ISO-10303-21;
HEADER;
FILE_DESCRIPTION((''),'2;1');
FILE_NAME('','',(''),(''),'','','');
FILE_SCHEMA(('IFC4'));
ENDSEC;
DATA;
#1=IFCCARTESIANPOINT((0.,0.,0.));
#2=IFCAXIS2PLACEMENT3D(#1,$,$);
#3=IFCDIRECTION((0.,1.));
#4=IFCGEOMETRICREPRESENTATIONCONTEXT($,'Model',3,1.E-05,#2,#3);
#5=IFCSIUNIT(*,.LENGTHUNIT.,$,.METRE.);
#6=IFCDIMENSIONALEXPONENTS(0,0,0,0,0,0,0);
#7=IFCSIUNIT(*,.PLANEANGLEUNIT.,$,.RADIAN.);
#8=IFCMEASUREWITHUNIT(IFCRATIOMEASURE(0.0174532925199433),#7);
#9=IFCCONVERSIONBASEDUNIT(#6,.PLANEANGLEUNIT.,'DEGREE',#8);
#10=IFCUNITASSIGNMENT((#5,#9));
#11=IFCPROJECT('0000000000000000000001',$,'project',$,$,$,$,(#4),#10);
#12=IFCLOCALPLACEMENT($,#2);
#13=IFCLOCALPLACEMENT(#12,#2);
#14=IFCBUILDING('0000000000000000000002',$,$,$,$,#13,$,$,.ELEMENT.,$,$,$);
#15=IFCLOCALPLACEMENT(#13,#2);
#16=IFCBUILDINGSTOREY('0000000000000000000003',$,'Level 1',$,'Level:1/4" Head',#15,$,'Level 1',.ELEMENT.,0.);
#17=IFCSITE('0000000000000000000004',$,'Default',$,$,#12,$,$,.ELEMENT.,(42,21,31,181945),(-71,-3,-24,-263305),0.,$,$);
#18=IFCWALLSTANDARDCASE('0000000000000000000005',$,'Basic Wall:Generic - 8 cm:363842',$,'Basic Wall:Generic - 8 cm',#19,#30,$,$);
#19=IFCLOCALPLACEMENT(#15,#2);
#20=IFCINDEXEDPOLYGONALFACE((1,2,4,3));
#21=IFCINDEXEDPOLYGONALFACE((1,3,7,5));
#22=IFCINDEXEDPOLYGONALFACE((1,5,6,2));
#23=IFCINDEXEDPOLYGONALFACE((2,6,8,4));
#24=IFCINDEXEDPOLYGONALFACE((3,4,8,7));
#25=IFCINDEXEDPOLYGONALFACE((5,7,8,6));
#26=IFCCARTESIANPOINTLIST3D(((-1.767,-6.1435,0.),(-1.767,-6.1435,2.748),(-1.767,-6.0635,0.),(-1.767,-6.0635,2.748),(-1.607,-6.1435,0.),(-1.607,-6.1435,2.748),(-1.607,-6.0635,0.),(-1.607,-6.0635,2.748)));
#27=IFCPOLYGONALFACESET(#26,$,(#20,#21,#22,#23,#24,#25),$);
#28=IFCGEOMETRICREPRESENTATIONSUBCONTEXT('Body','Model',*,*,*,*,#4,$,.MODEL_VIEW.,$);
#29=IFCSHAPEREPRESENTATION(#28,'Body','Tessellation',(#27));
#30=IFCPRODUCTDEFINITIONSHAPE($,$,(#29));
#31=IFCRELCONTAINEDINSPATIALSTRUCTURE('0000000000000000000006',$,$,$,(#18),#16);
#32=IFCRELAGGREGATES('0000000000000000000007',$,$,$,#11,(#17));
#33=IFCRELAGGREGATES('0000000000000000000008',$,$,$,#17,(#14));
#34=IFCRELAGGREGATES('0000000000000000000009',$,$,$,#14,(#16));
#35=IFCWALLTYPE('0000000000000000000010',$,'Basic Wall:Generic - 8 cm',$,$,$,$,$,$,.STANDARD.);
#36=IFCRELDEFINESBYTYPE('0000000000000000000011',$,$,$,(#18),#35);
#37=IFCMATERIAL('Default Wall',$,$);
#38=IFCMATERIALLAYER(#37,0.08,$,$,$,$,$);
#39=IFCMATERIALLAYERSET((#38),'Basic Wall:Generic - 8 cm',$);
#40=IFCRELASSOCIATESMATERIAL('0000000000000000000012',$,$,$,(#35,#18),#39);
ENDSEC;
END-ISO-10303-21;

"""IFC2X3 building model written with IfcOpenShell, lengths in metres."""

from ifc_helpers import new_model, entity, si_unit, converted_unit, direction, frame, frame_2d, origin, place, context, subcontext, project, spatial, rectangle, extrude, material, layer, layer_set, layer_usage, type_object, element, save


model = new_model("IFC2X3")

# Units and contexts
model_context = context("Model", 3, precision=1e-05, world=origin(), true_north=direction((0.0, 1.0)))
body_context = subcontext(model_context, "Body", "Model", "MODEL_VIEW")
ifc_project = project(units=[si_unit("LENGTHUNIT", "METRE"), converted_unit("PLANEANGLEUNIT", "DEGREE", entity("IfcRatioMeasure", 0.0174532925199433), si_unit("PLANEANGLEUNIT", "RADIAN"), dimensions=[0, 0, 0, 0, 0, 0, 0])], contexts=[model_context])

# Site, building, storey
site_placement = place(None, origin())
site = spatial("IfcSite", under=ifc_project, at=site_placement, Name="Default", CompositionType="ELEMENT", RefLatitude=(42, 21, 31, 181945), RefLongitude=(-71, -3, -24, -263305), RefElevation=0.0)
building_placement = place(site_placement, origin())
building = spatial("IfcBuilding", under=site, at=building_placement, CompositionType="ELEMENT")
storey_placement = place(building_placement, origin())
storey = spatial("IfcBuildingStorey", under=building, at=storey_placement, Name="Level 1", ObjectType="Level:1/4\" Head", LongName="Level 1", CompositionType="ELEMENT", Elevation=0.0)

# Wall
ifc_material = material(Name="Default Wall")
ifc_layer = layer(ifc_material, 0.08)
ifc_layer_set = layer_set([ifc_layer], Name="Basic Wall:Generic - 8 cm")
wall_type = type_object("IfcWallType", Name="Basic Wall:Generic - 8 cm", PredefinedType="STANDARD", material=ifc_layer_set)
ifc_layer_usage_1 = layer_usage(ifc_layer_set, "AXIS2", "NEGATIVE", 0.04)
wall_1_placement = place(storey_placement, frame((-1.607, -6.1035, 0.0), z_axis=(0.0, 0.0, 1.0), x_axis=(-1.0, 0.0, 0.0)))
element("IfcWallStandardCase", 1, at=wall_1_placement, inside=storey, type_object=wall_type, material=ifc_layer_usage_1, Name="Basic Wall:Generic - 8 cm:363842", ObjectType="Basic Wall:Generic - 8 cm", context=body_context, shape_type="SweptSolid", body=[
    extrude(rectangle(XDim=0.16, YDim=0.08, at=frame_2d((0.08, 0.0), x_axis=(-1.0, 0.0))), origin(), (0.0, 0.0, 1.0), 2.748),
])

save(model, "model.ifc")
